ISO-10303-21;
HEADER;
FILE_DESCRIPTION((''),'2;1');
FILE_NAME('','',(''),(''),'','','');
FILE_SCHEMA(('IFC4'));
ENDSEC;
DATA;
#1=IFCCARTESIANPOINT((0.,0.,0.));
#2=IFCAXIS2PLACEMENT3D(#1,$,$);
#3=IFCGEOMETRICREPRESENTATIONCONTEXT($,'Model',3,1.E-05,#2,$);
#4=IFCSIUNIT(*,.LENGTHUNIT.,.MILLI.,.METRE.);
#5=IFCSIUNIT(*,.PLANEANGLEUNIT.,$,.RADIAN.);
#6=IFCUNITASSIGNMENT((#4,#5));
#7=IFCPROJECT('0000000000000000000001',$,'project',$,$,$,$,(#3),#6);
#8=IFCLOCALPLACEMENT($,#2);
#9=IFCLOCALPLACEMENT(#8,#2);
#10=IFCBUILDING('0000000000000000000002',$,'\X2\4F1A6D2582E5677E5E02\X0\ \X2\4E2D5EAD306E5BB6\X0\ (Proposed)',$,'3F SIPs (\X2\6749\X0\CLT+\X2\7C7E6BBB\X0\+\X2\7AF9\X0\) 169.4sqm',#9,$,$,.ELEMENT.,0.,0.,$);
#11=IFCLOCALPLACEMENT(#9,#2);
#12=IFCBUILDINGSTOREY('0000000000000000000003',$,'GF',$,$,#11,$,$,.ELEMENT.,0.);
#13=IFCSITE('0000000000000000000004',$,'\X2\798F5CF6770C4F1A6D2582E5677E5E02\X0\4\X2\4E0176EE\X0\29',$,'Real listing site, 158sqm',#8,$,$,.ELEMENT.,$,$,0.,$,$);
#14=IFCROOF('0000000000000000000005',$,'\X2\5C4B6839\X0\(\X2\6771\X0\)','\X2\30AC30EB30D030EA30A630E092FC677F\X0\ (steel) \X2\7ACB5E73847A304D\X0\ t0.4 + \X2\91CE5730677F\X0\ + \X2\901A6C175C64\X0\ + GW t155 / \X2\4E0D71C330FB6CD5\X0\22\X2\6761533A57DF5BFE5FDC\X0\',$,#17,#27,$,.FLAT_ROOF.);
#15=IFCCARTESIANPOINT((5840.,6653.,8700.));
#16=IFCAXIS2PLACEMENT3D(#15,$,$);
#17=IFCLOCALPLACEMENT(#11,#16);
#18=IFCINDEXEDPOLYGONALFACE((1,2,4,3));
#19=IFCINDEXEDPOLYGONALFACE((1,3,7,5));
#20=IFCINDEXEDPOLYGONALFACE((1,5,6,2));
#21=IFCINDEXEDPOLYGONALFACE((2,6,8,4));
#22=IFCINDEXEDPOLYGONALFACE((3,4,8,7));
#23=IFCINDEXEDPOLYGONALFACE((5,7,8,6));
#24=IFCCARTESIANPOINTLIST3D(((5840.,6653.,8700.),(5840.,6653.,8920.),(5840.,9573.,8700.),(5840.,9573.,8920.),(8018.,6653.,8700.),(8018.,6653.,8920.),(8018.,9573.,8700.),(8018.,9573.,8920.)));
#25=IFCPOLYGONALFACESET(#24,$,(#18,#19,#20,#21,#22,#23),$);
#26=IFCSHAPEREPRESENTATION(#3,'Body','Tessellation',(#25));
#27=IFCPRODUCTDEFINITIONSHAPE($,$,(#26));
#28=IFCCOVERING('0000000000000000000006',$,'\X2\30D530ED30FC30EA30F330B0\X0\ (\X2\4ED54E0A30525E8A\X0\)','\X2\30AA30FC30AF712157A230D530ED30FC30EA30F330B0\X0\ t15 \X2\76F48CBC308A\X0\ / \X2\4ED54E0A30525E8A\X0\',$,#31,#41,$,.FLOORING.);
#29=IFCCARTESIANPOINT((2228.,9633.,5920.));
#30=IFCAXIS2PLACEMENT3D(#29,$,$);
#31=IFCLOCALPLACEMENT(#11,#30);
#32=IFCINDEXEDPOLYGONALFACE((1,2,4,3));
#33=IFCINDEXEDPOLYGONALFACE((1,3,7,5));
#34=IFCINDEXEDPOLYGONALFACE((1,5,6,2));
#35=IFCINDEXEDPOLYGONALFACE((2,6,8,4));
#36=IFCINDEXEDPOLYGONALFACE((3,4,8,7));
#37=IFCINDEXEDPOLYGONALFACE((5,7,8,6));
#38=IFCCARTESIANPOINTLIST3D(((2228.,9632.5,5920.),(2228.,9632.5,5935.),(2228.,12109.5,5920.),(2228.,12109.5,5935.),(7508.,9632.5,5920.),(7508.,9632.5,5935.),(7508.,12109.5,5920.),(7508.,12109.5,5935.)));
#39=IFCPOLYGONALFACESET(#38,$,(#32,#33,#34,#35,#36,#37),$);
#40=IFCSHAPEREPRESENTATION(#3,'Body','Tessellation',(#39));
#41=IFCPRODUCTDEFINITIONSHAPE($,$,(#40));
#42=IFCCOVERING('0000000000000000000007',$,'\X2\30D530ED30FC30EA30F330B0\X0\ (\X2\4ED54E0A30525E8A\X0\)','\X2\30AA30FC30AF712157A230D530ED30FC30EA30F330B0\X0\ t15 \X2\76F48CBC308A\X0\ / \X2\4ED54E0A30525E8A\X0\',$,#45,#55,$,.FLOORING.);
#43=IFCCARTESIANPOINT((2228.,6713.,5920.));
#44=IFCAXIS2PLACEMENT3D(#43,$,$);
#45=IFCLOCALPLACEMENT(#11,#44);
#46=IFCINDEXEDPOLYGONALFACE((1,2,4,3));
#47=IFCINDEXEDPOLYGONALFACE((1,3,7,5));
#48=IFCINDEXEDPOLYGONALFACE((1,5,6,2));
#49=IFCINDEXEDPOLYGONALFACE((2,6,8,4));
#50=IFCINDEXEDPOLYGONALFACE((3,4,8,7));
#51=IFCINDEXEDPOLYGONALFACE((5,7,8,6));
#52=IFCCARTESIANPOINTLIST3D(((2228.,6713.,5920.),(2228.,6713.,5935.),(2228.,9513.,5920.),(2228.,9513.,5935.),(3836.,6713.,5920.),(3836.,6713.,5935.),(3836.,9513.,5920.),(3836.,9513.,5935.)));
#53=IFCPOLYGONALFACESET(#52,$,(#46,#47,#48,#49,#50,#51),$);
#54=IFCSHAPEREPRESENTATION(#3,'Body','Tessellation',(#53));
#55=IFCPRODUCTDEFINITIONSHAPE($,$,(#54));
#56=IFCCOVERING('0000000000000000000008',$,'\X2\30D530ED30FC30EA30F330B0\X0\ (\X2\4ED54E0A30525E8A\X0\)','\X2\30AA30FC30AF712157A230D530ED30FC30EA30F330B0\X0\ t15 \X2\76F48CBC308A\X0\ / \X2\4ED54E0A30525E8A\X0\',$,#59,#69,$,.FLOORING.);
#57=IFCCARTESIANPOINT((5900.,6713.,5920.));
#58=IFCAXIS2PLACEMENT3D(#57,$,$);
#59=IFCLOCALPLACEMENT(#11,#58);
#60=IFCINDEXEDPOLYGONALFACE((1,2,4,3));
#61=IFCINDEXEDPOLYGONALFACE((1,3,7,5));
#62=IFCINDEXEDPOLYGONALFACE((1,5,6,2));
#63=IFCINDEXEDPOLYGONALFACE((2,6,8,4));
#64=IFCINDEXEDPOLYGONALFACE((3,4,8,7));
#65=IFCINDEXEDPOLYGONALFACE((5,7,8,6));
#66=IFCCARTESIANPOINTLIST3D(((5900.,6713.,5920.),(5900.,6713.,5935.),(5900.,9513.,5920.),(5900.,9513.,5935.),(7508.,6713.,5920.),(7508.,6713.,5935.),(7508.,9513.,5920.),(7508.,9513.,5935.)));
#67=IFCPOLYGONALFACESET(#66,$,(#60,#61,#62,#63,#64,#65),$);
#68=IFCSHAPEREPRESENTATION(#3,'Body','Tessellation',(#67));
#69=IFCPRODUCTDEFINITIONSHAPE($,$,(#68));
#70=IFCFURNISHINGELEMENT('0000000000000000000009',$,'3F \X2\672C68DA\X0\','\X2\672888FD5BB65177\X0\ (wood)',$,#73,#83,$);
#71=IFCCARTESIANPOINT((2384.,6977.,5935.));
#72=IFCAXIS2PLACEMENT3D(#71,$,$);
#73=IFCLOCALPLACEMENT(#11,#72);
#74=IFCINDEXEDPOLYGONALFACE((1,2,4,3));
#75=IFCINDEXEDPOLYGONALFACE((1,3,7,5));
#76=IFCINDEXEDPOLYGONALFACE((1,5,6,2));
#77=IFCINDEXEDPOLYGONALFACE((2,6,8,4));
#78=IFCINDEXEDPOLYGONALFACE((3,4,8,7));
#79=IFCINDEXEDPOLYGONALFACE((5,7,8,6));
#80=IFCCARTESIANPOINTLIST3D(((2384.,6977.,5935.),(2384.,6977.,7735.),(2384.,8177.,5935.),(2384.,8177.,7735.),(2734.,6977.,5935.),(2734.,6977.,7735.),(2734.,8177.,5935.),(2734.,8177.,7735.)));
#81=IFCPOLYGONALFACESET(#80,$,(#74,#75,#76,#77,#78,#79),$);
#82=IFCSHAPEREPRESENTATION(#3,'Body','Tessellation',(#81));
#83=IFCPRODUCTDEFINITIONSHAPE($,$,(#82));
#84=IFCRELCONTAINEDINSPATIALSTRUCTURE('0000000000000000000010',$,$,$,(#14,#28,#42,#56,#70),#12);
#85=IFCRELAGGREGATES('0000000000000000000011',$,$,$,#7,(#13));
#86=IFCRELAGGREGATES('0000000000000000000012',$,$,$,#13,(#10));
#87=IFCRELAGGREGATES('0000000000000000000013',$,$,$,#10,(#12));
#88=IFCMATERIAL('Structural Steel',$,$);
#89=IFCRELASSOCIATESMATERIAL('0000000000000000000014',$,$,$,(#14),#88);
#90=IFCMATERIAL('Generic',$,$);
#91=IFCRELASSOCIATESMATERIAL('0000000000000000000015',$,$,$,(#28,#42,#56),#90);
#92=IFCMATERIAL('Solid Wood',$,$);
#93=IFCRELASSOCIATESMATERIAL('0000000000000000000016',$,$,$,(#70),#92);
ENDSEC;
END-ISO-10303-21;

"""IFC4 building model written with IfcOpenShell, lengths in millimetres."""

from ifc_helpers import new_model, si_unit, frame, frame_2d, origin, place, context, project, spatial, rectangle, extrude, material, element, save


model = new_model("IFC4")

# Units and contexts
model_context = context("Model", 3, precision=1e-05, world=origin())
ifc_project = project(units=[si_unit("LENGTHUNIT", "METRE", prefix="MILLI"), si_unit("PLANEANGLEUNIT", "RADIAN")], contexts=[model_context])

# Site, building, storey
site_placement = place(None, origin())
site = spatial("IfcSite", under=ifc_project, at=site_placement, Name="福島県会津若松市4丁目29", ObjectType="Real listing site, 158sqm", CompositionType="ELEMENT", RefElevation=0.0)
building_placement = place(site_placement, origin())
building = spatial("IfcBuilding", under=site, at=building_placement, Name="会津若松市 中庭の家 (Proposed)", ObjectType="3F SIPs (杉CLT+籾殻+竹) 169.4sqm", CompositionType="ELEMENT", ElevationOfRefHeight=0.0, ElevationOfTerrain=0.0)
storey_placement = place(building_placement, origin())
storey = spatial("IfcBuildingStorey", under=building, at=storey_placement, Name="GF", CompositionType="ELEMENT", Elevation=0.0)

# Shared definitions
ifc_material_1 = material(Name="Solid Wood")

# Shared definitions
ifc_material_2 = material(Name="Generic")

# Roof
ifc_material_3 = material(Name="Structural Steel")
roof_1_placement = place(storey_placement, frame((5840.0, 6653.0, 8700.0)))
element("IfcRoof", 1, at=roof_1_placement, inside=storey, material=ifc_material_3, Name="屋根(東)", Description="ガルバリウム鋼板 (steel) 立平葺き t0.4 + 野地板 + 通気層 + GW t155 / 不燃・法22条区域対応", PredefinedType="FLAT_ROOF", context=model_context, shape_type="SweptSolid", body=[
    extrude(rectangle(XDim=2178.0, YDim=2920.0, at=frame_2d((1089.0, 1460.0))), frame((5840.0, 6653.0, 8700.0)), (0.0, 0.0, 1.0), 220.0),
])

# Coverings
covering_1_placement = place(storey_placement, frame((2228.0, 9633.0, 5920.0)))
element("IfcCovering", 2, at=covering_1_placement, inside=storey, material=ifc_material_2, Name="フローリング (仕上げ床)", Description="オーク無垢フローリング t15 直貼り / 仕上げ床", PredefinedType="FLOORING", context=model_context, shape_type="SweptSolid", body=[
    extrude(rectangle(XDim=5280.0, YDim=2477.0, at=frame_2d((2640.0, 1238.0))), frame((2228.0, 9633.0, 5920.0)), (0.0, 0.0, 1.0), 15.0),
])
covering_2_placement = place(storey_placement, frame((2228.0, 6713.0, 5920.0)))
element("IfcCovering", 3, at=covering_2_placement, inside=storey, material=ifc_material_2, Name="フローリング (仕上げ床)", Description="オーク無垢フローリング t15 直貼り / 仕上げ床", PredefinedType="FLOORING", context=model_context, shape_type="SweptSolid", body=[
    extrude(rectangle(XDim=1608.0, YDim=2800.0, at=frame_2d((804.0, 1400.0))), frame((2228.0, 6713.0, 5920.0)), (0.0, 0.0, 1.0), 15.0),
])
covering_3_placement = place(storey_placement, frame((5900.0, 6713.0, 5920.0)))
element("IfcCovering", 4, at=covering_3_placement, inside=storey, material=ifc_material_2, Name="フローリング (仕上げ床)", Description="オーク無垢フローリング t15 直貼り / 仕上げ床", PredefinedType="FLOORING", context=model_context, shape_type="SweptSolid", body=[
    extrude(rectangle(XDim=1608.0, YDim=2800.0, at=frame_2d((804.0, 1400.0))), frame((5900.0, 6713.0, 5920.0)), (0.0, 0.0, 1.0), 15.0),
])

# Furnishing element
furnishing_placement = place(storey_placement, frame((2384.0, 6977.0, 5935.0)))
element("IfcFurnishingElement", 5, at=furnishing_placement, inside=storey, material=ifc_material_1, Name="3F 本棚", Description="木製家具 (wood)", context=model_context, shape_type="SweptSolid", body=[
    extrude(rectangle(XDim=350.0, YDim=1200.0, at=frame_2d((175.0, 600.0))), frame((2384.0, 6977.0, 5935.0)), (0.0, 0.0, 1.0), 1800.0),
])

save(model, "model.ifc")
